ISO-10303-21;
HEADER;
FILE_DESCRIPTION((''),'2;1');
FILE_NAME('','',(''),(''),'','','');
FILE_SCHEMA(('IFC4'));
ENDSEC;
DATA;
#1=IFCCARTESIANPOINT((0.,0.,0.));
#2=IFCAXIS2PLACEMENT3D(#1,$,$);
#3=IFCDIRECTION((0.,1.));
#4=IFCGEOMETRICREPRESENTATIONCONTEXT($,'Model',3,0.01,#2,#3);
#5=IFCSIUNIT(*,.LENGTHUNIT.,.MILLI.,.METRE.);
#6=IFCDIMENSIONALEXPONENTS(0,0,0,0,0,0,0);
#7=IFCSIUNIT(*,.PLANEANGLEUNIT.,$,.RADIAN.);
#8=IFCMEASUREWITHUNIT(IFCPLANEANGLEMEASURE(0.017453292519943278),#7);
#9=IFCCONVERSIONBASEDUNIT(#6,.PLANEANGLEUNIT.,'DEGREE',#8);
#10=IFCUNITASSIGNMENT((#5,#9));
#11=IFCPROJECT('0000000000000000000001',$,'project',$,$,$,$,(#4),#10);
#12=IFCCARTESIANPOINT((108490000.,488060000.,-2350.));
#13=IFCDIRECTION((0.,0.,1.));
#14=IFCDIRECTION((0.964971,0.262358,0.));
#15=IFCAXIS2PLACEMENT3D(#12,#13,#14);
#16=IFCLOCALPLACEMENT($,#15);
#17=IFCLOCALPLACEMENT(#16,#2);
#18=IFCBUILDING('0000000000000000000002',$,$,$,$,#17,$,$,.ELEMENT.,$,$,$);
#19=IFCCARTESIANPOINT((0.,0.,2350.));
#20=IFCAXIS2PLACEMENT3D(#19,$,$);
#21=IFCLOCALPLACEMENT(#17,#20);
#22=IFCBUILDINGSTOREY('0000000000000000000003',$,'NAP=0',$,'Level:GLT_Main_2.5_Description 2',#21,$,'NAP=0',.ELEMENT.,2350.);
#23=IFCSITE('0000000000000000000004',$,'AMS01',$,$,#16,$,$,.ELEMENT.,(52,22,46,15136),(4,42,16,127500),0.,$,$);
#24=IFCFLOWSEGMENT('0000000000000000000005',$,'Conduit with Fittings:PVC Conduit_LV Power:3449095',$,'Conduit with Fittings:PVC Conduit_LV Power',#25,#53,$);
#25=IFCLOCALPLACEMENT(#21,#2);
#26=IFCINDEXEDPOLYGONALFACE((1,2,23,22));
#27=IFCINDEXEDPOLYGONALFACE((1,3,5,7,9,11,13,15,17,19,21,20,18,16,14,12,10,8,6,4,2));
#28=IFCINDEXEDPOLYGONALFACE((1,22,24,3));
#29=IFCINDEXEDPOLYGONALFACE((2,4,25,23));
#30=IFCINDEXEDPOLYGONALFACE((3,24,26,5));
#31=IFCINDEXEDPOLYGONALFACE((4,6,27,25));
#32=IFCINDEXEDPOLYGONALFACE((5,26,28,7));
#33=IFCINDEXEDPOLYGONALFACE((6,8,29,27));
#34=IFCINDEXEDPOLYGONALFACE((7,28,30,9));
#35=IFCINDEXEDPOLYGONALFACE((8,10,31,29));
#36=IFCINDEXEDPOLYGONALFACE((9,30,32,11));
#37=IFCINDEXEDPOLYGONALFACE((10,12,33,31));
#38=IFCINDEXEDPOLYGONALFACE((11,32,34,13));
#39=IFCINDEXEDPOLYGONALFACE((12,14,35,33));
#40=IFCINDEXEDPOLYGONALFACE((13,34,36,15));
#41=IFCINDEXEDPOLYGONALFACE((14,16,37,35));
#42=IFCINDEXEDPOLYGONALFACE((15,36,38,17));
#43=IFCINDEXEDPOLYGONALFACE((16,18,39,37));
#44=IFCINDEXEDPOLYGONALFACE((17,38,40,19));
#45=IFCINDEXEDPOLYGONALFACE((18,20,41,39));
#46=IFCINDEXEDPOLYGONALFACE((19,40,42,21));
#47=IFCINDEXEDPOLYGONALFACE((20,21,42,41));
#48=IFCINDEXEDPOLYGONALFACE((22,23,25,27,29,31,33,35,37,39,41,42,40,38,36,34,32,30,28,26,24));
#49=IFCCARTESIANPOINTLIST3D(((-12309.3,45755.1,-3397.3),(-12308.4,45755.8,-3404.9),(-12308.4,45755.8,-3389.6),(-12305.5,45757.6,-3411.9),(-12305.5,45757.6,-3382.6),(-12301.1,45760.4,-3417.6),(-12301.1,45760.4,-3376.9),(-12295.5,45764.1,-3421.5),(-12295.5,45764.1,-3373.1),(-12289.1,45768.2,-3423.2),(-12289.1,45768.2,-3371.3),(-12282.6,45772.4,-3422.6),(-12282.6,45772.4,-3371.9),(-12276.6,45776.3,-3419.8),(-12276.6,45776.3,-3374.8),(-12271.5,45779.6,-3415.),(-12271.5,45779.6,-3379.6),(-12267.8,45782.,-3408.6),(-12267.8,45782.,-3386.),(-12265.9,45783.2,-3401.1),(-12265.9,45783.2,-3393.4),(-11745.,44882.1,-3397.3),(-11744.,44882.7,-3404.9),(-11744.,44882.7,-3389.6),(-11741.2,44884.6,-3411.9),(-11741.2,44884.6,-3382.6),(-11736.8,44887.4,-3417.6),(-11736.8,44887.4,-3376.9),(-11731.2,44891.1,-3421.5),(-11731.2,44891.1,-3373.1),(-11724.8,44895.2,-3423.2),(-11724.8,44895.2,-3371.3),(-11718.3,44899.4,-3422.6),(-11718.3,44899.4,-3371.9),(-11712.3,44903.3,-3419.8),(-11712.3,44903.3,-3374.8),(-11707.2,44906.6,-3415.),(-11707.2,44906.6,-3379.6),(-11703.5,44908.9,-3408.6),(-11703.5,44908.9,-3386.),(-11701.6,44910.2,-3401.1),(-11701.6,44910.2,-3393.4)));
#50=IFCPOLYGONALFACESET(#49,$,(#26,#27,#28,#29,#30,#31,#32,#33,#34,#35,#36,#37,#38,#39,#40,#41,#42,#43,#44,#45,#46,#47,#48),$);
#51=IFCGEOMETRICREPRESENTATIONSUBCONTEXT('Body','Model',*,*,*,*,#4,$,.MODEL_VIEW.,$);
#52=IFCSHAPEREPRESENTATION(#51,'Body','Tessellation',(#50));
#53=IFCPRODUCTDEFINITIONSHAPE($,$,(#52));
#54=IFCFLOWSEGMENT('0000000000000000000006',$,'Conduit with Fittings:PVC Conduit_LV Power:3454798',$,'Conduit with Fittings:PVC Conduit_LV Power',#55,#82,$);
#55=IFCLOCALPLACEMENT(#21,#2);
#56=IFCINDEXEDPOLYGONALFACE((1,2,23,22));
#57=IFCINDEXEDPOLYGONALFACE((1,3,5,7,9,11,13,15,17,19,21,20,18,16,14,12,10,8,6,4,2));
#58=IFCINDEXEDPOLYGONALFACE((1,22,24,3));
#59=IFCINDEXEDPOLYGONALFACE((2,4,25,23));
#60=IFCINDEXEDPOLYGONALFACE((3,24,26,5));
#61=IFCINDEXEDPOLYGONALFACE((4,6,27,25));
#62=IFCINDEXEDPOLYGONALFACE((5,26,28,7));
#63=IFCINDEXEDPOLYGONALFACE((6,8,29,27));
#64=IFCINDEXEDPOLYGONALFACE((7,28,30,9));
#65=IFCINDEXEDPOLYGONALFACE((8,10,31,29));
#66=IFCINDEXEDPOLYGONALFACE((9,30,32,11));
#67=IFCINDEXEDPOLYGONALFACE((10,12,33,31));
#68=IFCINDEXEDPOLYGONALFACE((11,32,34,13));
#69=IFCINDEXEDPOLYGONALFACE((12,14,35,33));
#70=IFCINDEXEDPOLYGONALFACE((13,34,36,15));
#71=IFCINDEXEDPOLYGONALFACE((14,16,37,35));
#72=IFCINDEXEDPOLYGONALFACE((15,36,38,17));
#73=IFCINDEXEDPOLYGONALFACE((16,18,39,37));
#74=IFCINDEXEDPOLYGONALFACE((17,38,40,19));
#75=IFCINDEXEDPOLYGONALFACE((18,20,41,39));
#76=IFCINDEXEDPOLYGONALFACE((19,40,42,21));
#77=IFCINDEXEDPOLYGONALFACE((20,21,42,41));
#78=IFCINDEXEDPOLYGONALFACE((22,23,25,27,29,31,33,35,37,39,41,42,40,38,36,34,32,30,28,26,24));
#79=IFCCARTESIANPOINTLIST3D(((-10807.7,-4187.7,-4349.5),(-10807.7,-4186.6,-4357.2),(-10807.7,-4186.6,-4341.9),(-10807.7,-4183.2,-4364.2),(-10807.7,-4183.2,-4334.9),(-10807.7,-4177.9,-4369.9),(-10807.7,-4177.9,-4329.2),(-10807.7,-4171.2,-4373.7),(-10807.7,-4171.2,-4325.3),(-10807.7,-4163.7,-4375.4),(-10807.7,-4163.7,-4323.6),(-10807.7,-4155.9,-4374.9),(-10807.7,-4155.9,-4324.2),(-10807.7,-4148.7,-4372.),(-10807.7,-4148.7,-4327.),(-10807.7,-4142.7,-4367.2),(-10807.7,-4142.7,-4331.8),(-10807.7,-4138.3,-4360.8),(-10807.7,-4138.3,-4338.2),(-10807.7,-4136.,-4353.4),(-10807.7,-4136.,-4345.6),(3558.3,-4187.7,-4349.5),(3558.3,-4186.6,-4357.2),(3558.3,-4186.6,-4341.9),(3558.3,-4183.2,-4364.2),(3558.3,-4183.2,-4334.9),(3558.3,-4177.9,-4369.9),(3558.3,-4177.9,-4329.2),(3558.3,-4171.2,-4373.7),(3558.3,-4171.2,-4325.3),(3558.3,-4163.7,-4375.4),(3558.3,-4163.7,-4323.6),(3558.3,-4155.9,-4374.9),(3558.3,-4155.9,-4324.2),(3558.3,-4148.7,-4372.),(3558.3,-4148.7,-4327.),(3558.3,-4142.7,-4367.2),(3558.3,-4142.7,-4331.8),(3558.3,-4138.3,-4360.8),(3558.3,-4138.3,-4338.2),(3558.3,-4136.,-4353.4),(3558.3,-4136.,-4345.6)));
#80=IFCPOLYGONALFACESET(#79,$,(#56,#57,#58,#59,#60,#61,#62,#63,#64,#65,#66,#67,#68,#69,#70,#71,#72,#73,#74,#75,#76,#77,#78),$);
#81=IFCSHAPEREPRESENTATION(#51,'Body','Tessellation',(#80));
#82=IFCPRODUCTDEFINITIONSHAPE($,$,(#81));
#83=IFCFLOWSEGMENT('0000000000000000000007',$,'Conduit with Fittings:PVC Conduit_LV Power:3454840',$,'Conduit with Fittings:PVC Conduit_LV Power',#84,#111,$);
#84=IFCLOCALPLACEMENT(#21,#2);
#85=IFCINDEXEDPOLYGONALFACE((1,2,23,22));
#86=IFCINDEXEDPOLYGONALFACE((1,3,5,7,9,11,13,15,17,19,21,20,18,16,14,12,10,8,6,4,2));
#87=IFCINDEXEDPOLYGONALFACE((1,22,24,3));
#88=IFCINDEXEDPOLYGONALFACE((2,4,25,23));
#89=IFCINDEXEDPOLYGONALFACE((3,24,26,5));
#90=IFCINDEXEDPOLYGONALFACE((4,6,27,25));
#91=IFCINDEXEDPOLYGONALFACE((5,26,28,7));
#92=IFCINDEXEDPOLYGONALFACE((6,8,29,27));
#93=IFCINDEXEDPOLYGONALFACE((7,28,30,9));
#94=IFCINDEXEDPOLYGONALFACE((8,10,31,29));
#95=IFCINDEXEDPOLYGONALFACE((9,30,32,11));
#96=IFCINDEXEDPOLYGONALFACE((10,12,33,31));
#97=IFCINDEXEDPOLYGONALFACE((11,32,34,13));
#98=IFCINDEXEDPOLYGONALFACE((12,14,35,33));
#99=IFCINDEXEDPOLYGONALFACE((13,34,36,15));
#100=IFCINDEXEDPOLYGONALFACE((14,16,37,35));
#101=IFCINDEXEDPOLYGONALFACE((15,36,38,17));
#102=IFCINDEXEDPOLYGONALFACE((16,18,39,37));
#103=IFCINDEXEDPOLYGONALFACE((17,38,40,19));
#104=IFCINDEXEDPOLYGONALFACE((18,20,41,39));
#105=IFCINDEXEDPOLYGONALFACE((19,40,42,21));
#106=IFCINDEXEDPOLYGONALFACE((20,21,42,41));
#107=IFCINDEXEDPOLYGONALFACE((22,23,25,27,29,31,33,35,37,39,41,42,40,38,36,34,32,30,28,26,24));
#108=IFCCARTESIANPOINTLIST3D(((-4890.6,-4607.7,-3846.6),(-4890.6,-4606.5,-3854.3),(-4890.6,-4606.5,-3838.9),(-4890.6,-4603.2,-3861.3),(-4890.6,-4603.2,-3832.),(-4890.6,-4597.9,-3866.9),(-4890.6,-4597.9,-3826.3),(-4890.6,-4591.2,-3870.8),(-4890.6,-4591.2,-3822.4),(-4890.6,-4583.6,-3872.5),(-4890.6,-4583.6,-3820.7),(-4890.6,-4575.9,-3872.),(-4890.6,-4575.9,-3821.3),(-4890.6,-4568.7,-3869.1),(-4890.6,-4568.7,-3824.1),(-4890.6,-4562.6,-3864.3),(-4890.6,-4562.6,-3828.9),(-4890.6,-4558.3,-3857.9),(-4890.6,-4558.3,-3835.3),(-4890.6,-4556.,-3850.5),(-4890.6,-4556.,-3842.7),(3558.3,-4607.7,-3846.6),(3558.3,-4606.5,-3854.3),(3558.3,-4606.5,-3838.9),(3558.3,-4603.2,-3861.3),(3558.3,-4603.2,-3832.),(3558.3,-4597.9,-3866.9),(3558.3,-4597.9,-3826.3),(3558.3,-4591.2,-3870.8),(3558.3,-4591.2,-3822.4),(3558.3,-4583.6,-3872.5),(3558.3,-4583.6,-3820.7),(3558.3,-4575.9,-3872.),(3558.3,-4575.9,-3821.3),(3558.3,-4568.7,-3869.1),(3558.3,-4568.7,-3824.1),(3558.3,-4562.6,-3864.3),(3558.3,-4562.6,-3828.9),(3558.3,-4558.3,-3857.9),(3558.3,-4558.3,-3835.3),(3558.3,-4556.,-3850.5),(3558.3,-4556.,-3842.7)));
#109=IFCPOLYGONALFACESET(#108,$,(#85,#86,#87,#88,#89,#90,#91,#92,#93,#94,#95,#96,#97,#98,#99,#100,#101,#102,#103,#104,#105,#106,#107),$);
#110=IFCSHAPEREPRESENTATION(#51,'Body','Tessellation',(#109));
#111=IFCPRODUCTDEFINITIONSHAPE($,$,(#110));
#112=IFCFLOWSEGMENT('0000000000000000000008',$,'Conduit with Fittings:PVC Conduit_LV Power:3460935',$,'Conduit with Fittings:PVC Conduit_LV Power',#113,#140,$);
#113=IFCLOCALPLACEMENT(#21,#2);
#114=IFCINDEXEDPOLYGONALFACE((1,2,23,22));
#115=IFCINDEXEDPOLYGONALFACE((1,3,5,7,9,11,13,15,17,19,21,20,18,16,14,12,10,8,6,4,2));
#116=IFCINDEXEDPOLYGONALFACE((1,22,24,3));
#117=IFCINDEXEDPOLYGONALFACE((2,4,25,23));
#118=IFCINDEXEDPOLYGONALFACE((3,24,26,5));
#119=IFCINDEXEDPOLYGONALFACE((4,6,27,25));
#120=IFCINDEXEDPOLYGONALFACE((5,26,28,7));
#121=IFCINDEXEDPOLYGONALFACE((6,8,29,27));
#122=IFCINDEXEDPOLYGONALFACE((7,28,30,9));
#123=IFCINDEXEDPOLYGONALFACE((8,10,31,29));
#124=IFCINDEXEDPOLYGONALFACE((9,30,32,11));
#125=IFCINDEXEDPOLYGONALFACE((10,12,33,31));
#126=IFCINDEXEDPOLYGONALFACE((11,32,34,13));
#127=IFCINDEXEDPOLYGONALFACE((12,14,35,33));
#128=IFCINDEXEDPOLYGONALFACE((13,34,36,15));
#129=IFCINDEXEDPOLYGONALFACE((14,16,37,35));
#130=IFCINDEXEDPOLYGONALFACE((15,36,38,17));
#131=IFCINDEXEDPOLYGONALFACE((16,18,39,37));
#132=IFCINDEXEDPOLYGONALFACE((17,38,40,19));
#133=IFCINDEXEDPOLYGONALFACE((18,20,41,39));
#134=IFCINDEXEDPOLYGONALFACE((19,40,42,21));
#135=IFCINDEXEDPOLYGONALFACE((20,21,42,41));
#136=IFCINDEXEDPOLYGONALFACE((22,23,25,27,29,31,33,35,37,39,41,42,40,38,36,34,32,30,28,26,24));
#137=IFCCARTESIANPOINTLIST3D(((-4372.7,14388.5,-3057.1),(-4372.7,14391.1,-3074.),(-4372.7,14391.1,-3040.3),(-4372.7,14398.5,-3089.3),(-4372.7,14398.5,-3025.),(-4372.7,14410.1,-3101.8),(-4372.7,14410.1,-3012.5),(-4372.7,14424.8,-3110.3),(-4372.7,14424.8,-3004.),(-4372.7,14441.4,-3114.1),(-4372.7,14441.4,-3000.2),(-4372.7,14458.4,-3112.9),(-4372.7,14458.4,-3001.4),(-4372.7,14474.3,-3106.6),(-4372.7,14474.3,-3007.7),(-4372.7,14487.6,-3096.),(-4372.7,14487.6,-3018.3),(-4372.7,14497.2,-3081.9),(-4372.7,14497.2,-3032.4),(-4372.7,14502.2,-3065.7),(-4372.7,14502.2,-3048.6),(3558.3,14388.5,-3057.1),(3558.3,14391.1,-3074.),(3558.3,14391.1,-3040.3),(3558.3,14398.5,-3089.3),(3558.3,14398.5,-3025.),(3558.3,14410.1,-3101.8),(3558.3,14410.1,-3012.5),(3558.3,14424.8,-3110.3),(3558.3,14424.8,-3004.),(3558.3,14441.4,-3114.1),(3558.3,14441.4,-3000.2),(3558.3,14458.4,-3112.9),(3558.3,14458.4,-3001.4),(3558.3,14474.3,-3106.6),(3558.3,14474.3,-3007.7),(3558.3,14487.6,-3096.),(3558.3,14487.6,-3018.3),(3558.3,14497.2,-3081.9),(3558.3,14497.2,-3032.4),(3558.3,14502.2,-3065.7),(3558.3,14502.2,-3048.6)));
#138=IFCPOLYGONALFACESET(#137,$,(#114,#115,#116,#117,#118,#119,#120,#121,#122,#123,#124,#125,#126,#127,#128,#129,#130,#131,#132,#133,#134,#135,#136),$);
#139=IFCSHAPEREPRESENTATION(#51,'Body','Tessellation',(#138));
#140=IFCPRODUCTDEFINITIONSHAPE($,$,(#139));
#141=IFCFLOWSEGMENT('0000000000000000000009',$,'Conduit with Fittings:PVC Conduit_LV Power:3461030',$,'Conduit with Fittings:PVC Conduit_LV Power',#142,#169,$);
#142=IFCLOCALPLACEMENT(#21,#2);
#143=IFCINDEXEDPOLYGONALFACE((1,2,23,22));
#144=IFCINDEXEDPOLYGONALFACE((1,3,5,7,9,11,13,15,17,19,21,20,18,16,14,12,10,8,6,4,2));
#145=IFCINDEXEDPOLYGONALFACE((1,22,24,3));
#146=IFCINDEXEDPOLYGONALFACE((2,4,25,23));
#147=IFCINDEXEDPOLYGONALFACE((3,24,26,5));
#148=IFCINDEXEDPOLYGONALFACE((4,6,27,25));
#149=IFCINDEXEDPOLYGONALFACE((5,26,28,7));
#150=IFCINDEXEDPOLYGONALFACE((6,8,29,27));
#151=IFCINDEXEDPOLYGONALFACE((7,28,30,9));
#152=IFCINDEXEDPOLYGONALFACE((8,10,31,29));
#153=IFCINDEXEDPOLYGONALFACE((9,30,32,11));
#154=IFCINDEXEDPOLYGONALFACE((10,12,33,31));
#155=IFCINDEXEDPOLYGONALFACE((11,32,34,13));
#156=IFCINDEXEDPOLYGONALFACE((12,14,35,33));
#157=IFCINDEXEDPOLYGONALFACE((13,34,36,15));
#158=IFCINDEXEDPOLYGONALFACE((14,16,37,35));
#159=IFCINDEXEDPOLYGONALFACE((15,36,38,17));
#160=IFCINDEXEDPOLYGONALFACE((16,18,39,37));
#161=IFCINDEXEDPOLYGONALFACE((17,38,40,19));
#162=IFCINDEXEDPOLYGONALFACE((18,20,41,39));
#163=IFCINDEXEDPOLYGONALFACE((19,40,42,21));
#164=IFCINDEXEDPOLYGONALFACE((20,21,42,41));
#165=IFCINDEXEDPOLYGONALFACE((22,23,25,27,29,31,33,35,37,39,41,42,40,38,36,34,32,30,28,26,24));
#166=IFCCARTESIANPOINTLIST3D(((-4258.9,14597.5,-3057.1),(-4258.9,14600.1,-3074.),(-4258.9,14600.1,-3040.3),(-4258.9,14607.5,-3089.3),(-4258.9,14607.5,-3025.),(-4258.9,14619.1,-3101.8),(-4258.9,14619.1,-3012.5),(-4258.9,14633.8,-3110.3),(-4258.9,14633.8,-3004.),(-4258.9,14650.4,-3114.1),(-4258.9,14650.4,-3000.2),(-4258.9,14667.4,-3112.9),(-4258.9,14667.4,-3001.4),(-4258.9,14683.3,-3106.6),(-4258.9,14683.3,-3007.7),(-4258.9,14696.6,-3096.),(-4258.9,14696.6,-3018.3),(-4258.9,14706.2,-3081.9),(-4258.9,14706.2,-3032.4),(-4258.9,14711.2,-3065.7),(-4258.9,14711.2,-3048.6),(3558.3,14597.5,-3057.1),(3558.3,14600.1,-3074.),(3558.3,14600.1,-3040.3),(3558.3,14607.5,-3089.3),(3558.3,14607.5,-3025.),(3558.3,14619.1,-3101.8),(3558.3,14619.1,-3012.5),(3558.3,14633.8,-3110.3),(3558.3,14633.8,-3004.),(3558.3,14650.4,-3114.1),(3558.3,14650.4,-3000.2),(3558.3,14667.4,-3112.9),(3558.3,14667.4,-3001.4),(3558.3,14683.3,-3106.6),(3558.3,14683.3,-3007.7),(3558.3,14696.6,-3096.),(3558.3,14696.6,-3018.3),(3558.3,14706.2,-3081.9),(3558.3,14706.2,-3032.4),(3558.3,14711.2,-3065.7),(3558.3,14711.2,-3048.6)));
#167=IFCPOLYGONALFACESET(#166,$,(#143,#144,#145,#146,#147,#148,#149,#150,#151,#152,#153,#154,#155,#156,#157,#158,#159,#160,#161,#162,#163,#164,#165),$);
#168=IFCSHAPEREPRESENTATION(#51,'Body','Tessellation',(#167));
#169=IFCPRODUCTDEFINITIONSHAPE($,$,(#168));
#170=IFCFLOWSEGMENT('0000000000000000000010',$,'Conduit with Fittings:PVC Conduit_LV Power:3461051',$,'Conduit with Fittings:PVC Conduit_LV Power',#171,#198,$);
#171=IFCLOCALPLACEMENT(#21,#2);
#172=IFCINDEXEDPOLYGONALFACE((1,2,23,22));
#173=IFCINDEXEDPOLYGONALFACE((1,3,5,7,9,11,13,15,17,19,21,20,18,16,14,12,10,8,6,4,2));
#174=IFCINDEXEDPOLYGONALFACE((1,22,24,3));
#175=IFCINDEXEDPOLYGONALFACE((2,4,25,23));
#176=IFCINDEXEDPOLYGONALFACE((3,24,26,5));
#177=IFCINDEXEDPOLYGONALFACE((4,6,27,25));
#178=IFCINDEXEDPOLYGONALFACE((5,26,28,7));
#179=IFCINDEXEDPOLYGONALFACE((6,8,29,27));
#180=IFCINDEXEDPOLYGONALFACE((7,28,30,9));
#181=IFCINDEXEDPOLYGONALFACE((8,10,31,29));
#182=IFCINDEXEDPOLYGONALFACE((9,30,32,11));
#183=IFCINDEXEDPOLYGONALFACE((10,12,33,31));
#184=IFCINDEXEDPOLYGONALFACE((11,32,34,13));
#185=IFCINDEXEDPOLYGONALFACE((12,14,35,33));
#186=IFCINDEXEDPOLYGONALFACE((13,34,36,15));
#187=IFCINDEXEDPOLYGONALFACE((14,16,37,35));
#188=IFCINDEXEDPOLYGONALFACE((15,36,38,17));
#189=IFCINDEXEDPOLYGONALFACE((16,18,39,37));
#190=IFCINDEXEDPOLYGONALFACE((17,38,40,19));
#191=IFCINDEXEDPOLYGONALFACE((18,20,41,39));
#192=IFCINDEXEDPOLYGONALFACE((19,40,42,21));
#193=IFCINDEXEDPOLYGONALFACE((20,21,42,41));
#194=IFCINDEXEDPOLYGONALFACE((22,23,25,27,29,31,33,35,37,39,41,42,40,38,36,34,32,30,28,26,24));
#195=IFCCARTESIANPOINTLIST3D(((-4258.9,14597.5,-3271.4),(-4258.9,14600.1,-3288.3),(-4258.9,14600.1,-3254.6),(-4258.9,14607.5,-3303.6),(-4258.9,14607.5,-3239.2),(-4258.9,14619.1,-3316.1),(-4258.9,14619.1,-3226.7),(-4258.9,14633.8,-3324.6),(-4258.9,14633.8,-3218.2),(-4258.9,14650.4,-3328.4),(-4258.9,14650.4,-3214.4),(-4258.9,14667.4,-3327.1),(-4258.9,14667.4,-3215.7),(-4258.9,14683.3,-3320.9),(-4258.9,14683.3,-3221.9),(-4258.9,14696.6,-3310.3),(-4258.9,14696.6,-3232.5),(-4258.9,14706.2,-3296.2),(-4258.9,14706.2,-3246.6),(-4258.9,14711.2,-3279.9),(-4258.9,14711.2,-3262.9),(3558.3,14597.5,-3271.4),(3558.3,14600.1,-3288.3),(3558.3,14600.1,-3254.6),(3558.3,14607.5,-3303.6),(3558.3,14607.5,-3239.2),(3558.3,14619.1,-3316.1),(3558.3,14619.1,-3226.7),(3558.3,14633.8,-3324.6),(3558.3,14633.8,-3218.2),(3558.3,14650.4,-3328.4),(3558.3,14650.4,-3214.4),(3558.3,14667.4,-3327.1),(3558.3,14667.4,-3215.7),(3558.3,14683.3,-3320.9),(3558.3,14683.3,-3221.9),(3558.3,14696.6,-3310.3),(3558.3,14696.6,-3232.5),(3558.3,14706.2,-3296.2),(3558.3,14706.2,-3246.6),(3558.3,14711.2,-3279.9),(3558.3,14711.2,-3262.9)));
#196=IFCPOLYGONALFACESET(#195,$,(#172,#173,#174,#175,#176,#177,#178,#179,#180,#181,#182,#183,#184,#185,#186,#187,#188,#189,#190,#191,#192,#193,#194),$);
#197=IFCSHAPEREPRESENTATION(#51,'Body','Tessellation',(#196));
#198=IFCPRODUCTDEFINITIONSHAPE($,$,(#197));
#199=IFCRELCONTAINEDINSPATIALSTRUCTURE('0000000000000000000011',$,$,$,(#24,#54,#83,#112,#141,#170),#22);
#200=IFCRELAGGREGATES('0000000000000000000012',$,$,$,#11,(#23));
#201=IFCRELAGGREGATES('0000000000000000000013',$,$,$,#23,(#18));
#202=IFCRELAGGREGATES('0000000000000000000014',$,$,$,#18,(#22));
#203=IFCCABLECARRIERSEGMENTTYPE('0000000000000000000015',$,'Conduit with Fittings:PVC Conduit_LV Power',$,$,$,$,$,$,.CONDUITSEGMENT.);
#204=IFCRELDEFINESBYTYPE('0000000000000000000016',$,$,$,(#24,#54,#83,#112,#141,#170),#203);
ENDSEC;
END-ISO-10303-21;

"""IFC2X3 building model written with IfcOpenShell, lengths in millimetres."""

from ifc_helpers import new_model, entity, si_unit, converted_unit, direction, frame, origin, origin_2d_with_axis, place, context, subcontext, project, spatial, circle, extrude, type_object, element, save


model = new_model("IFC2X3")

# Units and contexts
model_context = context("Model", 3, precision=0.01, world=origin(), true_north=direction((0.0, 1.0)))
body_context = subcontext(model_context, "Body", "Model", "MODEL_VIEW")
ifc_project = project(units=[si_unit("LENGTHUNIT", "METRE", prefix="MILLI"), converted_unit("PLANEANGLEUNIT", "DEGREE", entity("IfcPlaneAngleMeasure", 0.017453292519943278), si_unit("PLANEANGLEUNIT", "RADIAN"), dimensions=[0, 0, 0, 0, 0, 0, 0])], contexts=[model_context])

# Site, building, storey
site_placement = place(None, frame((108490000.0, 488060000.0, -2350.0), z_axis=(0.0, 0.0, 1.0), x_axis=(0.964971, 0.262358, 0.0)))
site = spatial("IfcSite", under=ifc_project, at=site_placement, Name="AMS01", CompositionType="ELEMENT", RefLatitude=(52, 22, 46, 15136), RefLongitude=(4, 42, 16, 127500), RefElevation=0.0)
building_placement = place(site_placement, origin())
building = spatial("IfcBuilding", under=site, at=building_placement, CompositionType="ELEMENT")
storey_placement = place(building_placement, frame((0.0, 0.0, 2350.0)))
storey = spatial("IfcBuildingStorey", under=building, at=storey_placement, Name="NAP=0", ObjectType="Level:GLT_Main_2.5_Description 2", LongName="NAP=0", CompositionType="ELEMENT", Elevation=2350.0)

# Flow segments
cable_carrier_segment_type = type_object("IfcCableCarrierSegmentType", Name="Conduit with Fittings:PVC Conduit_LV Power", PredefinedType="CONDUITSEGMENT")
flow_segment_1_placement = place(storey_placement, origin())
element("IfcFlowSegment", 1, at=flow_segment_1_placement, inside=storey, type_object=cable_carrier_segment_type, Name="Conduit with Fittings:PVC Conduit_LV Power:3449095", ObjectType="Conduit with Fittings:PVC Conduit_LV Power", context=body_context, shape_type="SweptSolid", body=[
    extrude(circle(Radius=26.0, at=origin_2d_with_axis()), frame((-12287.5, 45769.2, -3397.3), z_axis=(0.542856, -0.839826, 0.0), x_axis=(-0.839826, -0.542856, 0.0)), (0.0, 0.0, 1.0), 1039.5),
])
flow_segment_2_placement = place(storey_placement, origin())
element("IfcFlowSegment", 2, at=flow_segment_2_placement, inside=storey, type_object=cable_carrier_segment_type, Name="Conduit with Fittings:PVC Conduit_LV Power:3454798", ObjectType="Conduit with Fittings:PVC Conduit_LV Power", context=body_context, shape_type="SweptSolid", body=[
    extrude(circle(Radius=26.0, at=origin_2d_with_axis()), frame((-10807.7, -4161.7, -4349.5), z_axis=(1.0, 0.0, 0.0), x_axis=(0.0, -1.0, 0.0)), (0.0, 0.0, 1.0), 14366.1),
])
flow_segment_3_placement = place(storey_placement, origin())
element("IfcFlowSegment", 3, at=flow_segment_3_placement, inside=storey, type_object=cable_carrier_segment_type, Name="Conduit with Fittings:PVC Conduit_LV Power:3454840", ObjectType="Conduit with Fittings:PVC Conduit_LV Power", context=body_context, shape_type="SweptSolid", body=[
    extrude(circle(Radius=26.0, at=origin_2d_with_axis()), frame((-4890.6, -4581.7, -3846.6), z_axis=(1.0, 0.0, 0.0), x_axis=(0.0, -1.0, 0.0)), (0.0, 0.0, 1.0), 8449.0),
])
flow_segment_4_placement = place(storey_placement, origin())
element("IfcFlowSegment", 4, at=flow_segment_4_placement, inside=storey, type_object=cable_carrier_segment_type, Name="Conduit with Fittings:PVC Conduit_LV Power:3460935", ObjectType="Conduit with Fittings:PVC Conduit_LV Power", context=body_context, shape_type="SweptSolid", body=[
    extrude(circle(Radius=57.2, at=origin_2d_with_axis()), frame((-4372.7, 14445.7, -3057.1), z_axis=(1.0, 0.0, 0.0), x_axis=(0.0, -1.0, 0.0)), (0.0, 0.0, 1.0), 7931.0),
])
flow_segment_5_placement = place(storey_placement, origin())
element("IfcFlowSegment", 5, at=flow_segment_5_placement, inside=storey, type_object=cable_carrier_segment_type, Name="Conduit with Fittings:PVC Conduit_LV Power:3461030", ObjectType="Conduit with Fittings:PVC Conduit_LV Power", context=body_context, shape_type="SweptSolid", body=[
    extrude(circle(Radius=57.2, at=origin_2d_with_axis()), frame((-4258.9, 14654.7, -3057.1), z_axis=(1.0, 0.0, 0.0), x_axis=(0.0, -1.0, 0.0)), (0.0, 0.0, 1.0), 7817.2),
])
flow_segment_6_placement = place(storey_placement, origin())
element("IfcFlowSegment", 6, at=flow_segment_6_placement, inside=storey, type_object=cable_carrier_segment_type, Name="Conduit with Fittings:PVC Conduit_LV Power:3461051", ObjectType="Conduit with Fittings:PVC Conduit_LV Power", context=body_context, shape_type="SweptSolid", body=[
    extrude(circle(Radius=57.2, at=origin_2d_with_axis()), frame((-4258.9, 14654.7, -3271.4), z_axis=(1.0, 0.0, 0.0), x_axis=(0.0, -1.0, 0.0)), (0.0, 0.0, 1.0), 7817.2),
])

save(model, "model.ifc")
